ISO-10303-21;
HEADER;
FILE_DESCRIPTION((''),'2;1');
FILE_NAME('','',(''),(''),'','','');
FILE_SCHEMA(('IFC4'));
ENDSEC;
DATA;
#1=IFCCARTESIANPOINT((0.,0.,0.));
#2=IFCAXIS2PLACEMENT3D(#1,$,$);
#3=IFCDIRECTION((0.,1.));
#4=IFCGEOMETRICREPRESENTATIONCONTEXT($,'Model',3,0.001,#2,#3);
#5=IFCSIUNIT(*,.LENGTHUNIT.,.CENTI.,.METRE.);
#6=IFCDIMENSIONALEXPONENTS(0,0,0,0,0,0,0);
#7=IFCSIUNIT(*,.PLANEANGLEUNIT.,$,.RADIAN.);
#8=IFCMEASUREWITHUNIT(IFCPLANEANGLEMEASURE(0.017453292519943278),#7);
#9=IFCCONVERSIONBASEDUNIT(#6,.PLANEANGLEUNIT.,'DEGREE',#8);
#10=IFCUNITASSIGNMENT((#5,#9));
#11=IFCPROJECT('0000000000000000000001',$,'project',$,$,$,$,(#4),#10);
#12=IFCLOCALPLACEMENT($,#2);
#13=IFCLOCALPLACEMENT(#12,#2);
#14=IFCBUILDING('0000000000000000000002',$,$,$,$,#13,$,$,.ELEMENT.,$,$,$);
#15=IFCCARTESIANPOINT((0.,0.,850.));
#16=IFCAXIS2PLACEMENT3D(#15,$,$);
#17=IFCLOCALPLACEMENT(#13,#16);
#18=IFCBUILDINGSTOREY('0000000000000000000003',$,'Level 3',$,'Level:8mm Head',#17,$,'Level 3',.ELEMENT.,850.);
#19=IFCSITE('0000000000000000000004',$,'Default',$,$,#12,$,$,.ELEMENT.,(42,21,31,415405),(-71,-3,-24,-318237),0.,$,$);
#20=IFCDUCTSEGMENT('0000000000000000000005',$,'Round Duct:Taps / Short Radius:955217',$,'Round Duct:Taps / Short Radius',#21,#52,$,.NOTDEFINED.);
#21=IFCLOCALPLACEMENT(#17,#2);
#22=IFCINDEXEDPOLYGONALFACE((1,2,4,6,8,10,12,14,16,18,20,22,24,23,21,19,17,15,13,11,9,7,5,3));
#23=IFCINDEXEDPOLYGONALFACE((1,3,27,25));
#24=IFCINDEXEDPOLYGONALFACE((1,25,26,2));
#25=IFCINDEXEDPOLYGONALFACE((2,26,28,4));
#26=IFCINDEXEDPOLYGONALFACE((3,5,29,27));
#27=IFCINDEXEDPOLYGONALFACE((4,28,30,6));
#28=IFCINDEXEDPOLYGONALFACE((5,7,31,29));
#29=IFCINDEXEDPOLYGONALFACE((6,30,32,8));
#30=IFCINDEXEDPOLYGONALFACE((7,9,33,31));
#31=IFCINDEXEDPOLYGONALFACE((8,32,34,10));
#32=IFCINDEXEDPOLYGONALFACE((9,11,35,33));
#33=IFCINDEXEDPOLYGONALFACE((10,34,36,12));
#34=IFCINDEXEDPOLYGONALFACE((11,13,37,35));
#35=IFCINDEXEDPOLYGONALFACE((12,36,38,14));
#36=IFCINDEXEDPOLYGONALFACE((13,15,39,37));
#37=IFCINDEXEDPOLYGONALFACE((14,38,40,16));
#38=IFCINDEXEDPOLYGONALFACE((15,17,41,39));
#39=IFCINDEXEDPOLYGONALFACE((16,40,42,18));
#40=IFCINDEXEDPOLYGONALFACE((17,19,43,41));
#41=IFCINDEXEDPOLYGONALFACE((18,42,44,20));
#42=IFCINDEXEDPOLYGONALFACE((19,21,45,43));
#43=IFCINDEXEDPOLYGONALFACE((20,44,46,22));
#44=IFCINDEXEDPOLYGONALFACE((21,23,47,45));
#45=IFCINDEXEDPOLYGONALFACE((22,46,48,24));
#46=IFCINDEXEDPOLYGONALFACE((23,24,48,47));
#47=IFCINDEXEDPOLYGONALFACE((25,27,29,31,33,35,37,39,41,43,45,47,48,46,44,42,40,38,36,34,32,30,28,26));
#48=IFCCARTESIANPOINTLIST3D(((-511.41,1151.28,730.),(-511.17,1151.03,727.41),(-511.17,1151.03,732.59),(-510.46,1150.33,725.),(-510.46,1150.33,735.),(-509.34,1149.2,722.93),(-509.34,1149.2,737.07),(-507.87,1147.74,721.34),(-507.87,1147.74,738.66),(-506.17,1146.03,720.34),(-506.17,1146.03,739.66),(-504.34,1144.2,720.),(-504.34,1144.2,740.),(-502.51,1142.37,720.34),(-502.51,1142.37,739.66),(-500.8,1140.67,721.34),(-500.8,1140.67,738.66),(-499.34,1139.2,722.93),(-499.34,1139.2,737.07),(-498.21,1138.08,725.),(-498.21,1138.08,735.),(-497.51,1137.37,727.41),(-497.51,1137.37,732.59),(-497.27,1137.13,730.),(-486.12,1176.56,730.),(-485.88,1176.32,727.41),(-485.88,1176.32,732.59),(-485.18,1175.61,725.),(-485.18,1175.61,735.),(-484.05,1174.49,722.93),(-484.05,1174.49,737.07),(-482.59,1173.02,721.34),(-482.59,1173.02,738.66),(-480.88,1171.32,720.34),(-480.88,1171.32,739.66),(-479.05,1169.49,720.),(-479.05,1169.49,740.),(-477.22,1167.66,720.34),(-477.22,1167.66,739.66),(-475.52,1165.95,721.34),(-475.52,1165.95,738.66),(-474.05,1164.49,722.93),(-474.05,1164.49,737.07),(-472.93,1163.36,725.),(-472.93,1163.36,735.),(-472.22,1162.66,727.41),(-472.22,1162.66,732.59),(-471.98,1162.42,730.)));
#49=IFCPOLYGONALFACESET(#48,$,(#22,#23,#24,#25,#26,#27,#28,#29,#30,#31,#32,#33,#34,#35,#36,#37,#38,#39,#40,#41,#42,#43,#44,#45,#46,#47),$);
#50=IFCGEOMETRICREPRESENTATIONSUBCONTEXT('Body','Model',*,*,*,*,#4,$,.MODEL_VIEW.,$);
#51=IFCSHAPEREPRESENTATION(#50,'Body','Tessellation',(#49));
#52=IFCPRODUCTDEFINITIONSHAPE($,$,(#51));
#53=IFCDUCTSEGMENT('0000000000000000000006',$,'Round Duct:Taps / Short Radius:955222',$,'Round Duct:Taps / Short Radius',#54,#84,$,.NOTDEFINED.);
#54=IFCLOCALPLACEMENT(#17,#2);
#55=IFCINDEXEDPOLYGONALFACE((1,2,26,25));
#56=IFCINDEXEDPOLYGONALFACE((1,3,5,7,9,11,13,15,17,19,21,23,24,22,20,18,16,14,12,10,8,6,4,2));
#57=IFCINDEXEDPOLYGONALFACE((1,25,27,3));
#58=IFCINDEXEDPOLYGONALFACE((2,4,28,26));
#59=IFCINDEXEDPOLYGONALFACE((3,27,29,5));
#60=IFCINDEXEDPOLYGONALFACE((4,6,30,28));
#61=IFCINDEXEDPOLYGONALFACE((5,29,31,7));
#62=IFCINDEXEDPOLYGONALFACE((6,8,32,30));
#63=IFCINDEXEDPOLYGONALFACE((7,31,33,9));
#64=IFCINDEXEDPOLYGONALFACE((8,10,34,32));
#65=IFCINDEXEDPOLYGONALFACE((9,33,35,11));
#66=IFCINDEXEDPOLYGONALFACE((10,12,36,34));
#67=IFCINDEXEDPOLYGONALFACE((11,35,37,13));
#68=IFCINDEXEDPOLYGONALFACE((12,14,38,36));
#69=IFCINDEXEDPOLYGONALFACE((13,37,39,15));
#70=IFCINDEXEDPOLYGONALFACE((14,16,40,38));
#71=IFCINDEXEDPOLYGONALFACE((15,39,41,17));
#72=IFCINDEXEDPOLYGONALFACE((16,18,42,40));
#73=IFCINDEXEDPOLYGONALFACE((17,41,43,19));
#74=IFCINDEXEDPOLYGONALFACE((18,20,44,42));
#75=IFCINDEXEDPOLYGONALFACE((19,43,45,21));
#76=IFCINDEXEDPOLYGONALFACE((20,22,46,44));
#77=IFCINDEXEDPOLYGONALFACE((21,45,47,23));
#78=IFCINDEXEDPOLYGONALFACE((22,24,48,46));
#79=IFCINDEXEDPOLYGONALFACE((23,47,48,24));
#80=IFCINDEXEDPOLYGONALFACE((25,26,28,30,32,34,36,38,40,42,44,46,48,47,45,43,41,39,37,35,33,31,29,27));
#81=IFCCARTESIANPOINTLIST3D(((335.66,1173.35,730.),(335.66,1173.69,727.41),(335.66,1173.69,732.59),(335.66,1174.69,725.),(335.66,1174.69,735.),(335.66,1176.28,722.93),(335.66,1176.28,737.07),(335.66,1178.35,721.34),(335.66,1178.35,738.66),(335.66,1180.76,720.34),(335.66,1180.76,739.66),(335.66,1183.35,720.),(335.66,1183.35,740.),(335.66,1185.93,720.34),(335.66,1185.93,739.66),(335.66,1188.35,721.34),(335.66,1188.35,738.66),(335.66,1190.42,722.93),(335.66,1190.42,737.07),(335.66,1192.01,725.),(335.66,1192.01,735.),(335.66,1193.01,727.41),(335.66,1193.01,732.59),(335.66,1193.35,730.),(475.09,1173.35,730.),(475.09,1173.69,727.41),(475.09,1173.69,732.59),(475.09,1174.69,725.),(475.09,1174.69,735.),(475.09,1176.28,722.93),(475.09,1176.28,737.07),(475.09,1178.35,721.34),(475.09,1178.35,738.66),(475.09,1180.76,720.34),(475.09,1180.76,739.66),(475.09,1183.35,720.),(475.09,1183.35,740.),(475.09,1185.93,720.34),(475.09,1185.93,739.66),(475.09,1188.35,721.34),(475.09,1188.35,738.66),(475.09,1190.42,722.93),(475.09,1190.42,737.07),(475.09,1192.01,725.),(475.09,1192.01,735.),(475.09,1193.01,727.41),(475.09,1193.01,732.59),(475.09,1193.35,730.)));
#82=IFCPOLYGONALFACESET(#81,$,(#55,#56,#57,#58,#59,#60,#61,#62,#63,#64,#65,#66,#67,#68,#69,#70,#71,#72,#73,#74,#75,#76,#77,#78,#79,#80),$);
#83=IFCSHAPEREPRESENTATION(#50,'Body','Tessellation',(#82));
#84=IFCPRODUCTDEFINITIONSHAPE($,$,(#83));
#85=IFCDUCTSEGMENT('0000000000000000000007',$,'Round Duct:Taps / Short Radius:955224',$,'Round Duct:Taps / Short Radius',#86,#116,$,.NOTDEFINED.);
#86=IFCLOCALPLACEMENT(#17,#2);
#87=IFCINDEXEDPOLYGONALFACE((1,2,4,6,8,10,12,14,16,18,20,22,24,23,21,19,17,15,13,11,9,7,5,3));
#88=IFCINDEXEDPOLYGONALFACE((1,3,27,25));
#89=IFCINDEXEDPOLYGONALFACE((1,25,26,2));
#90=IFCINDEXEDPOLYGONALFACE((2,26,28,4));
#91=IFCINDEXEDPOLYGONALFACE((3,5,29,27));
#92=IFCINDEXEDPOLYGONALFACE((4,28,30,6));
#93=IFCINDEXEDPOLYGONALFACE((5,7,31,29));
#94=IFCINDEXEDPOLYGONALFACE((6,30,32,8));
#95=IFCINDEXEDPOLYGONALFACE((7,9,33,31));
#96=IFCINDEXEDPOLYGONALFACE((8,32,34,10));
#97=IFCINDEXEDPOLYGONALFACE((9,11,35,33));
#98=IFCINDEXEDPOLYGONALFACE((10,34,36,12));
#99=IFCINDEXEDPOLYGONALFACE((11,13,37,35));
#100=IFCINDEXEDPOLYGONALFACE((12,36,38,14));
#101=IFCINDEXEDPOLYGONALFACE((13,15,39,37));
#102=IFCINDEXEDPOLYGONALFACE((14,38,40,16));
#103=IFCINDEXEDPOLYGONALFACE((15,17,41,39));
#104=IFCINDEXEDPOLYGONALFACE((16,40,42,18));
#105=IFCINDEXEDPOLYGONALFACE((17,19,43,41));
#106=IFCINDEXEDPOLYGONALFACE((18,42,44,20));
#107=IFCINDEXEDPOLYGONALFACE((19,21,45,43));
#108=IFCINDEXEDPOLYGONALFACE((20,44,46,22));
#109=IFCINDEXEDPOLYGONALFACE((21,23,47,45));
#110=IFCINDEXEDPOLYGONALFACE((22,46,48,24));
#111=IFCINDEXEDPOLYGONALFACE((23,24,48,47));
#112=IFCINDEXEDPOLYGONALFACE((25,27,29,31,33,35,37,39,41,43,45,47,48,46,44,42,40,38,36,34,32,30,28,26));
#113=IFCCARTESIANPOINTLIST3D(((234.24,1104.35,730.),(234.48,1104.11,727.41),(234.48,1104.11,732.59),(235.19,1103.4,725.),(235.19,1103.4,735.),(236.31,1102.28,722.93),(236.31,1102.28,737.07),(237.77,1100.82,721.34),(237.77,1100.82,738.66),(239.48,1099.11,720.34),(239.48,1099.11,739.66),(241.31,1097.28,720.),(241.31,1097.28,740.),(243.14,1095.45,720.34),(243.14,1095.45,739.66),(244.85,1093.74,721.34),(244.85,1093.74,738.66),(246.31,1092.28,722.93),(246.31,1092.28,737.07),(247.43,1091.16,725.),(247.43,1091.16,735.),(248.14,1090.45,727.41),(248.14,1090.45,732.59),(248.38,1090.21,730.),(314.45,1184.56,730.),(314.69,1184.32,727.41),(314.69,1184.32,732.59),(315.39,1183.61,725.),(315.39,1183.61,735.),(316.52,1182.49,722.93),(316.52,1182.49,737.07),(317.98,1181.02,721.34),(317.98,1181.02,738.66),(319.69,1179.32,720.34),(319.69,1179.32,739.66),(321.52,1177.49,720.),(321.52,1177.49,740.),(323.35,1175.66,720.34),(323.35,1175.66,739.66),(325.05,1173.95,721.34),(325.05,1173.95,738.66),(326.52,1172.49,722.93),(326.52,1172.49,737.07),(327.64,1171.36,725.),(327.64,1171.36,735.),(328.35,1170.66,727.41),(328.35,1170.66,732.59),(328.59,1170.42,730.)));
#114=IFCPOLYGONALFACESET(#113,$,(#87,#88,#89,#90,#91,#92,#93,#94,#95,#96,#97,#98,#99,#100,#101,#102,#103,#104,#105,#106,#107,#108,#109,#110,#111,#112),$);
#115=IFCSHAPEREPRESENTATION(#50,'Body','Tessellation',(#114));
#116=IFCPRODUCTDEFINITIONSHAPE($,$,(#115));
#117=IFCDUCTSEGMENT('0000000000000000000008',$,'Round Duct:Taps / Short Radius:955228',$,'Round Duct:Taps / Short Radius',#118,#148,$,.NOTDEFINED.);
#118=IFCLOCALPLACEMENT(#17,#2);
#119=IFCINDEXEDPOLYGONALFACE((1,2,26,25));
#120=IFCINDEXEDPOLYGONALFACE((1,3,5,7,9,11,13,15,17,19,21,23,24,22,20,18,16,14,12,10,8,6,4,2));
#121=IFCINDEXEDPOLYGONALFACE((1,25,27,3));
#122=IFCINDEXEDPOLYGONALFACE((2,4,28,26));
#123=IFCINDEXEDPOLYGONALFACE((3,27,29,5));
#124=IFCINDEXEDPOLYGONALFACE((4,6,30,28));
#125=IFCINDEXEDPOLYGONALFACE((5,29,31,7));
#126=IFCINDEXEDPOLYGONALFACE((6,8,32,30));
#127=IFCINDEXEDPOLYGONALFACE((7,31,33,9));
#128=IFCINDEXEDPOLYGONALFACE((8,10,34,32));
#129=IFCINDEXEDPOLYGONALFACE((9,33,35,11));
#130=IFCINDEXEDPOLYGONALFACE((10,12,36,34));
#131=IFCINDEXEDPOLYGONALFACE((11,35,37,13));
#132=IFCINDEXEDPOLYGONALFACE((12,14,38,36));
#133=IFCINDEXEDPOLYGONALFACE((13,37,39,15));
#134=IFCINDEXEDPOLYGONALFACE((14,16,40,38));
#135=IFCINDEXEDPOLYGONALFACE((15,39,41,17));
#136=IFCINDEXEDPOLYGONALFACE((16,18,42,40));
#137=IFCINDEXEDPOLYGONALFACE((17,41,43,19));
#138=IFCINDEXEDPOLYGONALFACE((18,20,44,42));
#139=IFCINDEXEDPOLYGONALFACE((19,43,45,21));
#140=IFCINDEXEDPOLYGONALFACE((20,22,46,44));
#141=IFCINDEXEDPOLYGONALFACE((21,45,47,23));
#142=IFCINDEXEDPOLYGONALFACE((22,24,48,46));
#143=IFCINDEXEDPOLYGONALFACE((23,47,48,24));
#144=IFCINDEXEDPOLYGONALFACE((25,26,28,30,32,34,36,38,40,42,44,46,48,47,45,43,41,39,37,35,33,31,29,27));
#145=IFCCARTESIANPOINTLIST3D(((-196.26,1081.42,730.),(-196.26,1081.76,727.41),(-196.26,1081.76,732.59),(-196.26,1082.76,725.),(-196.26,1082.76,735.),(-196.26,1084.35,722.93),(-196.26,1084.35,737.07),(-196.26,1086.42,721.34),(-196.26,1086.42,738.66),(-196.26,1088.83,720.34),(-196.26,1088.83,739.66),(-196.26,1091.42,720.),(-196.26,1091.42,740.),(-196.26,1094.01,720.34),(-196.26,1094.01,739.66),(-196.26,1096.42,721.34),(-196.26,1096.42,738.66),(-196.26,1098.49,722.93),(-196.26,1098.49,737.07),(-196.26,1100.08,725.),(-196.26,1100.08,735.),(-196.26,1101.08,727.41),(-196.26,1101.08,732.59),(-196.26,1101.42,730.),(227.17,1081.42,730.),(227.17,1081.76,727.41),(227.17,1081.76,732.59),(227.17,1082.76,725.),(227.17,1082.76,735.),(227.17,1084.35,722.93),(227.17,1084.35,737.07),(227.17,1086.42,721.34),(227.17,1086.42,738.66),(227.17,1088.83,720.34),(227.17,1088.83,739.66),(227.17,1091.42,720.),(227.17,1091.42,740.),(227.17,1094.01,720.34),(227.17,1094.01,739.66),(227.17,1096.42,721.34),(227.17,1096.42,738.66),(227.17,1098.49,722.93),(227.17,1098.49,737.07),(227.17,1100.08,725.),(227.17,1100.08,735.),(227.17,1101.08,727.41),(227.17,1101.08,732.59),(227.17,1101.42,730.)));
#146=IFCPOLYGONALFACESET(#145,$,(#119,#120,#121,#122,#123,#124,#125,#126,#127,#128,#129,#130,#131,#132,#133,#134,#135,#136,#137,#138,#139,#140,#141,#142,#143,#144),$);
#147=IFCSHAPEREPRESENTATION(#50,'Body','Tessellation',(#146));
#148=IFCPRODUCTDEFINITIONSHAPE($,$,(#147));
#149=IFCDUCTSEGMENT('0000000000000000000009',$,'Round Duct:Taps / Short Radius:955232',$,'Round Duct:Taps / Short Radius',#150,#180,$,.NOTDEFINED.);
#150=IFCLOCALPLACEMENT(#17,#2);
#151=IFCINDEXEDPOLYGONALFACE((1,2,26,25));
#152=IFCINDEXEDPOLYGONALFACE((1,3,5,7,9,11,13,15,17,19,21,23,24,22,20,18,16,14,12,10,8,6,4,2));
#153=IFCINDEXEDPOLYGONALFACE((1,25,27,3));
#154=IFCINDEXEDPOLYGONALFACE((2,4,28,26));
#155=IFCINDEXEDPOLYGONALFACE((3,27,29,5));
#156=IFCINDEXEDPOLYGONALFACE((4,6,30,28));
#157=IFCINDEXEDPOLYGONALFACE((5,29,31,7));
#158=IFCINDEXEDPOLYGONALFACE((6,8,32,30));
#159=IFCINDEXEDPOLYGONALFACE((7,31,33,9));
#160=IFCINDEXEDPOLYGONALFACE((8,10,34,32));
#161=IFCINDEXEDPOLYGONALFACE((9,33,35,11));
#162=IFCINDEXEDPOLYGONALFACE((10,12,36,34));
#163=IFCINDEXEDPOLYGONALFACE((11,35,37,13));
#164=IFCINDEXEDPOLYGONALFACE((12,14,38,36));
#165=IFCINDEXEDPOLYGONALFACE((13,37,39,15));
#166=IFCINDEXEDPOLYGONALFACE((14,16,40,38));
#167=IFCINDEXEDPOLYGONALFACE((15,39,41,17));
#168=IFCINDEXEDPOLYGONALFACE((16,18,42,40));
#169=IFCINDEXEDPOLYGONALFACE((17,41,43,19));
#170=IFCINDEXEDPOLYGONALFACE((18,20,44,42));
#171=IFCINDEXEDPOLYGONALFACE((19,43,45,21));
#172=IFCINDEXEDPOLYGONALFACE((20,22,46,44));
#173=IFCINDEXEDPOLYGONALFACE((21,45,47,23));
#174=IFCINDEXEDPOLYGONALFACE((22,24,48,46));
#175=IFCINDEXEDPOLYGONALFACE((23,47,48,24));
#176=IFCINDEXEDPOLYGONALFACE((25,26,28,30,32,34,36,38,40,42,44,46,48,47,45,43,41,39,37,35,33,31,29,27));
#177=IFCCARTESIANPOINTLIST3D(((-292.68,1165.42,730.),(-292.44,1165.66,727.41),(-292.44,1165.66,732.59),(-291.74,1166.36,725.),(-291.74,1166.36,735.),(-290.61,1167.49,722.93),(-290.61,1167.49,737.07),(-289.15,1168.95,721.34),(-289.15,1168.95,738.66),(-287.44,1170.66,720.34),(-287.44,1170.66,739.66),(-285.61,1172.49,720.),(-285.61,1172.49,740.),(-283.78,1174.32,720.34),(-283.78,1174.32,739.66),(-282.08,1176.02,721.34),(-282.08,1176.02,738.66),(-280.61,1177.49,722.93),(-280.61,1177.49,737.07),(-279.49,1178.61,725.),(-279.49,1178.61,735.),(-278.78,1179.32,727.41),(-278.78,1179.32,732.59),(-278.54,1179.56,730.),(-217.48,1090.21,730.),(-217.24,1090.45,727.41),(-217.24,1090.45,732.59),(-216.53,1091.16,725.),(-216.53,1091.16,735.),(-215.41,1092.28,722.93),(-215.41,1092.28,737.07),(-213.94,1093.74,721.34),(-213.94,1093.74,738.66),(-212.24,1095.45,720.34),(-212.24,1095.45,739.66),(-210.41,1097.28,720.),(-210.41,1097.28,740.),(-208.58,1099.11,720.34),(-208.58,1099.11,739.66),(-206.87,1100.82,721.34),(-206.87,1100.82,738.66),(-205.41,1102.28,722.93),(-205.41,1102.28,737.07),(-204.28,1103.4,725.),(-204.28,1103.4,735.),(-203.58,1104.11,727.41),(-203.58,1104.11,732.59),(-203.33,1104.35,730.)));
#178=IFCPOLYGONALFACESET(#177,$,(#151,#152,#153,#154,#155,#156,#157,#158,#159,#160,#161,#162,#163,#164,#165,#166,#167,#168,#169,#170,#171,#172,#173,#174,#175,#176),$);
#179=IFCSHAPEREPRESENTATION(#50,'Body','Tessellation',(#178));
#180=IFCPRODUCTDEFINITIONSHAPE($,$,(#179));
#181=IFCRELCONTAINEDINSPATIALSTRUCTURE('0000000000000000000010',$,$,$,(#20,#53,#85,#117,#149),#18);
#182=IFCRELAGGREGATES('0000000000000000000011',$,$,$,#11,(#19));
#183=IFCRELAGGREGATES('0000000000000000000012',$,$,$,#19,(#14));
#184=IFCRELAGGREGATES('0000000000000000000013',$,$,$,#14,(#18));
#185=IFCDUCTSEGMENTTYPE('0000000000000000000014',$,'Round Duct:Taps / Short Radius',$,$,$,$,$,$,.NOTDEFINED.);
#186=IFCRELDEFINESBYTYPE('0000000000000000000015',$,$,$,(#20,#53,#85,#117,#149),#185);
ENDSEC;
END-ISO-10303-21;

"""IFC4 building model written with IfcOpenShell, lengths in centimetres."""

from ifc_helpers import new_model, entity, si_unit, converted_unit, direction, frame, origin, place, context, subcontext, project, spatial, arc, indexed_curve, outline, extrude, type_object, element, save


model = new_model("IFC4")

# Units and contexts
model_context = context("Model", 3, precision=0.001, world=origin(), true_north=direction((0.0, 1.0)))
body_context = subcontext(model_context, "Body", "Model", "MODEL_VIEW")
ifc_project = project(units=[si_unit("LENGTHUNIT", "METRE", prefix="CENTI"), converted_unit("PLANEANGLEUNIT", "DEGREE", entity("IfcPlaneAngleMeasure", 0.017453292519943278), si_unit("PLANEANGLEUNIT", "RADIAN"), dimensions=[0, 0, 0, 0, 0, 0, 0])], contexts=[model_context])

# Site, building, storey
site_placement = place(None, origin())
site = spatial("IfcSite", under=ifc_project, at=site_placement, Name="Default", CompositionType="ELEMENT", RefLatitude=(42, 21, 31, 415405), RefLongitude=(-71, -3, -24, -318237), RefElevation=0.0)
building_placement = place(site_placement, origin())
building = spatial("IfcBuilding", under=site, at=building_placement, CompositionType="ELEMENT")
storey_placement = place(building_placement, frame((0.0, 0.0, 850.0)))
storey = spatial("IfcBuildingStorey", under=building, at=storey_placement, Name="Level 3", ObjectType="Level:8mm Head", LongName="Level 3", CompositionType="ELEMENT", Elevation=850.0)

# Duct segments
duct_segment_type_1 = type_object("IfcDuctSegmentType", Name="Round Duct:Taps / Short Radius", PredefinedType="NOTDEFINED")
duct_segment_1_placement = place(storey_placement, origin())
element("IfcDuctSegment", 1, at=duct_segment_1_placement, inside=storey, type_object=duct_segment_type_1, Name="Round Duct:Taps / Short Radius:955217", ObjectType="Round Duct:Taps / Short Radius", PredefinedType="NOTDEFINED", context=body_context, shape_type="SweptSolid", body=[
    extrude(outline(indexed_curve([(10.0, 0.0), (7.07, 7.07), (0.0, 10.0), (-7.07, 7.07), (-10.0, 0.0), (-7.07, -7.07), (0.0, -10.0), (7.07, -7.07)], segments=[arc(1, 2, 3), arc(3, 4, 5), arc(5, 6, 7), arc(7, 8, 1)], self_intersect=False)), frame((-504.34, 1144.2, 730.0), z_axis=(0.707107, 0.707107, 0.0), x_axis=(-0.707107, 0.707107, 0.0)), (0.0, 0.0, 1.0), 35.76),
])
duct_segment_2_placement = place(storey_placement, origin())
element("IfcDuctSegment", 2, at=duct_segment_2_placement, inside=storey, type_object=duct_segment_type_1, Name="Round Duct:Taps / Short Radius:955222", ObjectType="Round Duct:Taps / Short Radius", PredefinedType="NOTDEFINED", context=body_context, shape_type="SweptSolid", body=[
    extrude(outline(indexed_curve([(10.0, 0.0), (7.07, 7.07), (0.0, 10.0), (-7.07, 7.07), (-10.0, 0.0), (-7.07, -7.07), (0.0, -10.0), (7.07, -7.07)], segments=[arc(1, 2, 3), arc(3, 4, 5), arc(5, 6, 7), arc(7, 8, 1)], self_intersect=False)), frame((335.66, 1183.35, 730.0), z_axis=(1.0, 0.0, 0.0), x_axis=(0.0, -1.0, 0.0)), (0.0, 0.0, 1.0), 139.43),
])
duct_segment_3_placement = place(storey_placement, origin())
element("IfcDuctSegment", 3, at=duct_segment_3_placement, inside=storey, type_object=duct_segment_type_1, Name="Round Duct:Taps / Short Radius:955224", ObjectType="Round Duct:Taps / Short Radius", PredefinedType="NOTDEFINED", context=body_context, shape_type="SweptSolid", body=[
    extrude(outline(indexed_curve([(10.0, 0.0), (7.07, 7.07), (0.0, 10.0), (-7.07, 7.07), (-10.0, 0.0), (-7.07, -7.07), (0.0, -10.0), (7.07, -7.07)], segments=[arc(1, 2, 3), arc(3, 4, 5), arc(5, 6, 7), arc(7, 8, 1)], self_intersect=False)), frame((241.31, 1097.28, 730.0), z_axis=(0.707107, 0.707107, 0.0), x_axis=(-0.707107, 0.707107, 0.0)), (0.0, 0.0, 1.0), 113.43),
])
duct_segment_4_placement = place(storey_placement, origin())
element("IfcDuctSegment", 4, at=duct_segment_4_placement, inside=storey, type_object=duct_segment_type_1, Name="Round Duct:Taps / Short Radius:955228", ObjectType="Round Duct:Taps / Short Radius", PredefinedType="NOTDEFINED", context=body_context, shape_type="SweptSolid", body=[
    extrude(outline(indexed_curve([(10.0, 0.0), (7.07, 7.07), (0.0, 10.0), (-7.07, 7.07), (-10.0, 0.0), (-7.07, -7.07), (0.0, -10.0), (7.07, -7.07)], segments=[arc(1, 2, 3), arc(3, 4, 5), arc(5, 6, 7), arc(7, 8, 1)], self_intersect=False)), frame((-196.26, 1091.42, 730.0), z_axis=(1.0, 0.0, 0.0), x_axis=(0.0, 1.0, 0.0)), (0.0, 0.0, 1.0), 423.43),
])
duct_segment_5_placement = place(storey_placement, origin())
element("IfcDuctSegment", 5, at=duct_segment_5_placement, inside=storey, type_object=duct_segment_type_1, Name="Round Duct:Taps / Short Radius:955232", ObjectType="Round Duct:Taps / Short Radius", PredefinedType="NOTDEFINED", context=body_context, shape_type="SweptSolid", body=[
    extrude(outline(indexed_curve([(10.0, 0.0), (7.07, 7.07), (0.0, 10.0), (-7.07, 7.07), (-10.0, 0.0), (-7.07, -7.07), (0.0, -10.0), (7.07, -7.07)], segments=[arc(1, 2, 3), arc(3, 4, 5), arc(5, 6, 7), arc(7, 8, 1)], self_intersect=False)), frame((-285.61, 1172.49, 730.0), z_axis=(0.707107, -0.707107, 0.0), x_axis=(0.707107, 0.707107, 0.0)), (0.0, 0.0, 1.0), 106.36),
])

save(model, "model.ifc")
